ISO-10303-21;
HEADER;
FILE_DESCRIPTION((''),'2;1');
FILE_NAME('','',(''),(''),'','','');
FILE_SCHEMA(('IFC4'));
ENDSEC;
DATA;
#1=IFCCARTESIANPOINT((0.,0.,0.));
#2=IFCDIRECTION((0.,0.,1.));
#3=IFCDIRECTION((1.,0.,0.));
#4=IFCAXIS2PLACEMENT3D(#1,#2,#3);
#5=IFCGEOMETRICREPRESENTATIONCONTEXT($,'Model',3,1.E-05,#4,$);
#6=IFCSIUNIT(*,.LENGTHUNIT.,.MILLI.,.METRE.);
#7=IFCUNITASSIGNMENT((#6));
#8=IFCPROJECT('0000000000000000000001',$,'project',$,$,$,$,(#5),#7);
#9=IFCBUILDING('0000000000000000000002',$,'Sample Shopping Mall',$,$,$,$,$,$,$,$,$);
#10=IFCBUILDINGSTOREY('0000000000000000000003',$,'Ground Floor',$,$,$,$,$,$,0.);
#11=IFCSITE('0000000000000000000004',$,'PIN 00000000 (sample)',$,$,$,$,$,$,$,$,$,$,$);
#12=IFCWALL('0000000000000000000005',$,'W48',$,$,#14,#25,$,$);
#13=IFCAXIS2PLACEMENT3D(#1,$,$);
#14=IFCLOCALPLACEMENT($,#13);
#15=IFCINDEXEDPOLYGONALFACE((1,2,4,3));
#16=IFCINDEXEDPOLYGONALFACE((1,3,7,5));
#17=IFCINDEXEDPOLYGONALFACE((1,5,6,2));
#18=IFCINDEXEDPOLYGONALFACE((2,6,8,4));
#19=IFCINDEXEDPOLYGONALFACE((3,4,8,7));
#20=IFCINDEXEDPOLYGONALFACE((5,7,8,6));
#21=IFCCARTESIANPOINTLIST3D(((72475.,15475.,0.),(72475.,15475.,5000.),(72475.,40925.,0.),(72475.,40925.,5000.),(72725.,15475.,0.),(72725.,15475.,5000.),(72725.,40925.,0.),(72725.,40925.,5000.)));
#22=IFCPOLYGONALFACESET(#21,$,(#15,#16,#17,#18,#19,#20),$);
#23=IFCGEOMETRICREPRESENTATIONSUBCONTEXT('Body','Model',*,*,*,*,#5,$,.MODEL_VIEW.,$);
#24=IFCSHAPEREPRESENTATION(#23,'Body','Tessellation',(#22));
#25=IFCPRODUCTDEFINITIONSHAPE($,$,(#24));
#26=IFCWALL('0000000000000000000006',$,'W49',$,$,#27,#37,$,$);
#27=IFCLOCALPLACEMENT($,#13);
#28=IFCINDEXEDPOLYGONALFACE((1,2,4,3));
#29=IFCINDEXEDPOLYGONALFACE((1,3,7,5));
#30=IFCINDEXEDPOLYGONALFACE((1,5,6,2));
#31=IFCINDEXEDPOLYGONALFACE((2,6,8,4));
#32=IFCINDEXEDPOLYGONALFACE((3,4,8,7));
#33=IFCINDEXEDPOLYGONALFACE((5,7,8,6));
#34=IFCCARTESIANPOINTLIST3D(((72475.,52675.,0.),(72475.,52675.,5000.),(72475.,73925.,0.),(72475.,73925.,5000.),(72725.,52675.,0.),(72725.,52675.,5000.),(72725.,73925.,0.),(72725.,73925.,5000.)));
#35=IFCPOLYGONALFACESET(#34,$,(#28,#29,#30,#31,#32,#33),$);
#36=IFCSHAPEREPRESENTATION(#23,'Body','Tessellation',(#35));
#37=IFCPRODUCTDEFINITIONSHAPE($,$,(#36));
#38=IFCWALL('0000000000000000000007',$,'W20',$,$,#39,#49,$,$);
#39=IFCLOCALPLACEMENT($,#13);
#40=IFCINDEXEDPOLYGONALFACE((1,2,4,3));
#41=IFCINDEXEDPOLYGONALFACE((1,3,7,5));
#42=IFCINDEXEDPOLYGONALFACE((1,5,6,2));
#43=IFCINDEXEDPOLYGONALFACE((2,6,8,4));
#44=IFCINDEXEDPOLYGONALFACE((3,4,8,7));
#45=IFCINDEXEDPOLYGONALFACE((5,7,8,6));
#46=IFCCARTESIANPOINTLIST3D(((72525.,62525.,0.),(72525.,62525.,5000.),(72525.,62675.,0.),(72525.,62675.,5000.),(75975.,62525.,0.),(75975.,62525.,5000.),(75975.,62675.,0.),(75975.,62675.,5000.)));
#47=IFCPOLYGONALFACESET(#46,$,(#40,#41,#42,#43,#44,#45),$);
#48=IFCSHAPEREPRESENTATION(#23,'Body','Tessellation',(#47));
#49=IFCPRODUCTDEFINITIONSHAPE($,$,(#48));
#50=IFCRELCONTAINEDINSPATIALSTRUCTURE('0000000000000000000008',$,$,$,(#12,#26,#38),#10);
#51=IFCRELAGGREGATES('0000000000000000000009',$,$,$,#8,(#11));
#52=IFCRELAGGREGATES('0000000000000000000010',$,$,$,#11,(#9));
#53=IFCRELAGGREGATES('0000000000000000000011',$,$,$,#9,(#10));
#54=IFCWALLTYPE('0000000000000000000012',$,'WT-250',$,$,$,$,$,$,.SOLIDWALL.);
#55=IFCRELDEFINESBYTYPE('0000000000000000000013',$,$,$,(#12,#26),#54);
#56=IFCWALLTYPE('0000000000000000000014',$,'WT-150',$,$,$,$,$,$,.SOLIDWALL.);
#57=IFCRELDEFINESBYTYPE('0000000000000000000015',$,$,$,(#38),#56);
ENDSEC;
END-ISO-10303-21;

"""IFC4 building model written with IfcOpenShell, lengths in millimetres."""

from ifc_helpers import new_model, si_unit, frame, origin_with_axes, place, context, subcontext, project, spatial, indexed_curve, outline, extrude, type_object, element, save


model = new_model("IFC4")

# Units and contexts
model_context = context("Model", 3, precision=1e-05, world=origin_with_axes())
body_context = subcontext(model_context, "Body", "Model", "MODEL_VIEW")
ifc_project = project(units=[si_unit("LENGTHUNIT", "METRE", prefix="MILLI")], contexts=[model_context])

# Site, building, storey
site = spatial("IfcSite", under=ifc_project, Name="PIN 00000000 (sample)")
building = spatial("IfcBuilding", under=site, Name="Sample Shopping Mall")
storey = spatial("IfcBuildingStorey", under=building, Name="Ground Floor", Elevation=0.0)

# Shared definitions
wall_type_1 = type_object("IfcWallType", Name="WT-250", PredefinedType="SOLIDWALL")

# Walls
wall_1_placement = place(None, frame((72725.0, 15475.0, 0.0), z_axis=(0.0, 0.0, 1.0), x_axis=(0.0, 1.0, 0.0)))
element("IfcWall", 1, at=wall_1_placement, inside=storey, type_object=wall_type_1, Name="W48", context=body_context, shape_type="SweptSolid", body=[
    extrude(outline(indexed_curve([(0.0, 0.0), (0.0, 250.0), (25450.0, 250.0), (25450.0, 0.0), (0.0, 0.0)], self_intersect=False)), origin_with_axes(), (0.0, 0.0, 1.0), 5000.0),
])
wall_2_placement = place(None, frame((72725.0, 52675.0, 0.0), z_axis=(0.0, 0.0, 1.0), x_axis=(0.0, 1.0, 0.0)))
element("IfcWall", 2, at=wall_2_placement, inside=storey, type_object=wall_type_1, Name="W49", context=body_context, shape_type="SweptSolid", body=[
    extrude(outline(indexed_curve([(0.0, 0.0), (0.0, 250.0), (21250.0, 250.0), (21250.0, 0.0), (0.0, 0.0)], self_intersect=False)), origin_with_axes(), (0.0, 0.0, 1.0), 5000.0),
])
wall_type_2 = type_object("IfcWallType", Name="WT-150", PredefinedType="SOLIDWALL")
wall_3_placement = place(None, frame((72525.0, 62525.0, 0.0), z_axis=(0.0, 0.0, 1.0), x_axis=(1.0, 0.0, 0.0)))
element("IfcWall", 3, at=wall_3_placement, inside=storey, type_object=wall_type_2, Name="W20", context=body_context, shape_type="SweptSolid", body=[
    extrude(outline(indexed_curve([(0.0, 0.0), (0.0, 150.0), (3450.0, 150.0), (3450.0, 0.0), (0.0, 0.0)], self_intersect=False)), origin_with_axes(), (0.0, 0.0, 1.0), 5000.0),
])

save(model, "model.ifc")
